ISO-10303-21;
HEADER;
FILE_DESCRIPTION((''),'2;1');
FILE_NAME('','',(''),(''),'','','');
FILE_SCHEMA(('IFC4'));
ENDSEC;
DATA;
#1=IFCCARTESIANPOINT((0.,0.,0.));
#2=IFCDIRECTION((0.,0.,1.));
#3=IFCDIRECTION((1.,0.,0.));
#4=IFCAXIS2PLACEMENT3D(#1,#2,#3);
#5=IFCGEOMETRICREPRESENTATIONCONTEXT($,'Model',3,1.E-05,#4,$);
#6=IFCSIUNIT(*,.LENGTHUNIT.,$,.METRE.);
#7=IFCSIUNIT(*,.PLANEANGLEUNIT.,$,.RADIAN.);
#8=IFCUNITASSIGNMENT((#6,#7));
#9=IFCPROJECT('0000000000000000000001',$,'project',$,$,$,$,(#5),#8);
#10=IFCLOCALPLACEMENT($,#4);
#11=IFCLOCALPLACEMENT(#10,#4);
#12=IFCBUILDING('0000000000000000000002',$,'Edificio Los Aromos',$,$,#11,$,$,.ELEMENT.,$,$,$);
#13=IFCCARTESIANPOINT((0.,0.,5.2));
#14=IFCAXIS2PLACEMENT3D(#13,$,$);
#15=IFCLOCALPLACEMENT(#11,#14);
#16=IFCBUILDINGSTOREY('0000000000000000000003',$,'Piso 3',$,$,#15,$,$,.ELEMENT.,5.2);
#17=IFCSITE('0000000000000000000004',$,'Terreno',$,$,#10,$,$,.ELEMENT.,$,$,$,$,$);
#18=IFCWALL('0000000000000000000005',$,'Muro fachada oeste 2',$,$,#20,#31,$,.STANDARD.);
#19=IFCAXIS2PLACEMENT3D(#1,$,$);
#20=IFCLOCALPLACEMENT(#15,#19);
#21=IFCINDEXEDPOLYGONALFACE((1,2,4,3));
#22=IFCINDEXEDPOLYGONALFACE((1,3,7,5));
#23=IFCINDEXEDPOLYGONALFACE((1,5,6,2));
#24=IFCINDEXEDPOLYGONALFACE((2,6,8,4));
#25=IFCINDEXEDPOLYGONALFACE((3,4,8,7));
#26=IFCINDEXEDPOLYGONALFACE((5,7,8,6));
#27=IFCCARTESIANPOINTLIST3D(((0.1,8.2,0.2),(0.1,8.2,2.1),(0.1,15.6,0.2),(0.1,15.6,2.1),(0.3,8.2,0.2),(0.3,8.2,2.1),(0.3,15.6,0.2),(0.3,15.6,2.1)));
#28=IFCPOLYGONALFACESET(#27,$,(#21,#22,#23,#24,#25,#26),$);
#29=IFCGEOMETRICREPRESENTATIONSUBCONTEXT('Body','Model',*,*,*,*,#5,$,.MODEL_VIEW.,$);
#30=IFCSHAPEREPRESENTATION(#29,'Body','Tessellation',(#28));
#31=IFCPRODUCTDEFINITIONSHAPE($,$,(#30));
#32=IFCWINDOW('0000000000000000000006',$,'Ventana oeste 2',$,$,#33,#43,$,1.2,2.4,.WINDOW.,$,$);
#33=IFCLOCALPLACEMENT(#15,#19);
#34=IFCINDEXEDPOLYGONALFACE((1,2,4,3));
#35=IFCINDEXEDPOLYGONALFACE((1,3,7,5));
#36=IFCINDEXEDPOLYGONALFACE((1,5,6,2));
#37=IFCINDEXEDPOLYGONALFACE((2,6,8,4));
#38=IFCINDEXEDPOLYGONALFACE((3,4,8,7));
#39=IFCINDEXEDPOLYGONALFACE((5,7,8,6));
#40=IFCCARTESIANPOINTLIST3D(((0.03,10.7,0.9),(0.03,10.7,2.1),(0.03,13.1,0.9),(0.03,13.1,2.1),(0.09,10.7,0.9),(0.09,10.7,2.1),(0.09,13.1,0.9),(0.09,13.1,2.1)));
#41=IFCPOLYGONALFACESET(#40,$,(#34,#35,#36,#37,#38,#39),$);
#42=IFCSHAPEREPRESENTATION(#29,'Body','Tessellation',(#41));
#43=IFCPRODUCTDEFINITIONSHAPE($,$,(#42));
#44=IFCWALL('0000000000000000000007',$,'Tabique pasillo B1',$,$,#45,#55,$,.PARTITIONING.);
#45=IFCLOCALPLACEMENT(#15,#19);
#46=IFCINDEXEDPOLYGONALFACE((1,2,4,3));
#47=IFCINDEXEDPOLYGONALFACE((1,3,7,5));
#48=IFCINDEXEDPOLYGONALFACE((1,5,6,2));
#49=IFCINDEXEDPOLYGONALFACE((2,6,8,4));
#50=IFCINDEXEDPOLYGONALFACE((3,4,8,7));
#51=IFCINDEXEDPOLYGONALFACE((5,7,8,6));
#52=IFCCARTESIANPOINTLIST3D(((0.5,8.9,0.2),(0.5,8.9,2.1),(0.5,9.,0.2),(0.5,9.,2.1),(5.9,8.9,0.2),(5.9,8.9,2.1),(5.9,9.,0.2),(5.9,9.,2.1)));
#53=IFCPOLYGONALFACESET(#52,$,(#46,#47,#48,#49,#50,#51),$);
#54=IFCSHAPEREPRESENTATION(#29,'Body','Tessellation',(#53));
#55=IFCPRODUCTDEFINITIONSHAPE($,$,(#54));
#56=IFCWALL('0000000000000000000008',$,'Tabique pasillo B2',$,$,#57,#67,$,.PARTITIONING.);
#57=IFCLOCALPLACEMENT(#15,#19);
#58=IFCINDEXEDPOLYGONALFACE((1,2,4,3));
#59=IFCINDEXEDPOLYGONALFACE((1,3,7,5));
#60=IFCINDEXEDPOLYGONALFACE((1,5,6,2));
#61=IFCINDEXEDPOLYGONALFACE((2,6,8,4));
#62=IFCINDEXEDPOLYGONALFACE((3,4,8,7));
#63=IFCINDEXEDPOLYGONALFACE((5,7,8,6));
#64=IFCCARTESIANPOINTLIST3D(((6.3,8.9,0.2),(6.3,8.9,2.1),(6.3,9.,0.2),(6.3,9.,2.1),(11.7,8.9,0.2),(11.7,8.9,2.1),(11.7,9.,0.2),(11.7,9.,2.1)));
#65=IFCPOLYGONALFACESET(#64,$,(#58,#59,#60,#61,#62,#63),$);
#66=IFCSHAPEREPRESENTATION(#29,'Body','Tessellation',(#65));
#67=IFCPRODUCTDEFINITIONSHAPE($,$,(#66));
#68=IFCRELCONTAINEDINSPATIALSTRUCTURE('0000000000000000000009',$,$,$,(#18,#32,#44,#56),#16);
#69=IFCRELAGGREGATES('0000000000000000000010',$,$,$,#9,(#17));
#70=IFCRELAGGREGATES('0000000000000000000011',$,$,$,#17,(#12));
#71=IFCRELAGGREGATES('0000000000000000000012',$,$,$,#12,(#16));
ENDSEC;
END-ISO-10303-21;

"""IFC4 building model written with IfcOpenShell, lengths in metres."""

from ifc_helpers import new_model, si_unit, frame, frame_2d, origin_with_axes, place, context, subcontext, project, spatial, rectangle, extrude, element, save


model = new_model("IFC4")

# Units and contexts
model_context = context("Model", 3, precision=1e-05, world=origin_with_axes())
body_context = subcontext(model_context, "Body", "Model", "MODEL_VIEW")
ifc_project = project(units=[si_unit("LENGTHUNIT", "METRE"), si_unit("PLANEANGLEUNIT", "RADIAN")], contexts=[model_context])

# Site, building, storey
site_placement = place(None, origin_with_axes())
site = spatial("IfcSite", under=ifc_project, at=site_placement, Name="Terreno", CompositionType="ELEMENT")
building_placement = place(site_placement, origin_with_axes())
building = spatial("IfcBuilding", under=site, at=building_placement, Name="Edificio Los Aromos", CompositionType="ELEMENT")
storey_placement = place(building_placement, frame((0.0, 0.0, 5.2)))
storey = spatial("IfcBuildingStorey", under=building, at=storey_placement, Name="Piso 3", CompositionType="ELEMENT", Elevation=5.2)

# Wall
wall_1_placement = place(storey_placement, frame((0.1, 8.2, 0.2)))
element("IfcWall", 1, at=wall_1_placement, inside=storey, Name="Muro fachada oeste 2", PredefinedType="STANDARD", context=body_context, shape_type="SweptSolid", body=[
    extrude(rectangle(XDim=0.2, YDim=7.4, at=frame_2d((0.1, 3.7))), origin_with_axes(), (0.0, 0.0, 1.0), 1.9),
])

# Window
window_1_placement = place(storey_placement, frame((0.03, 10.7, 0.9)))
element("IfcWindow", 2, at=window_1_placement, inside=storey, Name="Ventana oeste 2", OverallHeight=1.2, OverallWidth=2.4, PredefinedType="WINDOW", context=body_context, shape_type="SweptSolid", body=[
    extrude(rectangle(XDim=0.06, YDim=2.4, at=frame_2d((0.03, 1.2))), origin_with_axes(), (0.0, 0.0, 1.0), 1.2),
])

# Walls
for number, where, name in (
    (3, (0.5, 8.9, 0.2), "Tabique pasillo B1"),
    (4, (6.3, 8.9, 0.2), "Tabique pasillo B2"),
):
    element("IfcWall", number, at=place(storey_placement, frame(where)), inside=storey, Name=name, PredefinedType="PARTITIONING", context=body_context, shape_type="SweptSolid", body=[
        extrude(rectangle(XDim=5.4, YDim=0.1, at=frame_2d((2.7, 0.05))), origin_with_axes(), (0.0, 0.0, 1.0), 1.9),
    ])

save(model, "model.ifc")
